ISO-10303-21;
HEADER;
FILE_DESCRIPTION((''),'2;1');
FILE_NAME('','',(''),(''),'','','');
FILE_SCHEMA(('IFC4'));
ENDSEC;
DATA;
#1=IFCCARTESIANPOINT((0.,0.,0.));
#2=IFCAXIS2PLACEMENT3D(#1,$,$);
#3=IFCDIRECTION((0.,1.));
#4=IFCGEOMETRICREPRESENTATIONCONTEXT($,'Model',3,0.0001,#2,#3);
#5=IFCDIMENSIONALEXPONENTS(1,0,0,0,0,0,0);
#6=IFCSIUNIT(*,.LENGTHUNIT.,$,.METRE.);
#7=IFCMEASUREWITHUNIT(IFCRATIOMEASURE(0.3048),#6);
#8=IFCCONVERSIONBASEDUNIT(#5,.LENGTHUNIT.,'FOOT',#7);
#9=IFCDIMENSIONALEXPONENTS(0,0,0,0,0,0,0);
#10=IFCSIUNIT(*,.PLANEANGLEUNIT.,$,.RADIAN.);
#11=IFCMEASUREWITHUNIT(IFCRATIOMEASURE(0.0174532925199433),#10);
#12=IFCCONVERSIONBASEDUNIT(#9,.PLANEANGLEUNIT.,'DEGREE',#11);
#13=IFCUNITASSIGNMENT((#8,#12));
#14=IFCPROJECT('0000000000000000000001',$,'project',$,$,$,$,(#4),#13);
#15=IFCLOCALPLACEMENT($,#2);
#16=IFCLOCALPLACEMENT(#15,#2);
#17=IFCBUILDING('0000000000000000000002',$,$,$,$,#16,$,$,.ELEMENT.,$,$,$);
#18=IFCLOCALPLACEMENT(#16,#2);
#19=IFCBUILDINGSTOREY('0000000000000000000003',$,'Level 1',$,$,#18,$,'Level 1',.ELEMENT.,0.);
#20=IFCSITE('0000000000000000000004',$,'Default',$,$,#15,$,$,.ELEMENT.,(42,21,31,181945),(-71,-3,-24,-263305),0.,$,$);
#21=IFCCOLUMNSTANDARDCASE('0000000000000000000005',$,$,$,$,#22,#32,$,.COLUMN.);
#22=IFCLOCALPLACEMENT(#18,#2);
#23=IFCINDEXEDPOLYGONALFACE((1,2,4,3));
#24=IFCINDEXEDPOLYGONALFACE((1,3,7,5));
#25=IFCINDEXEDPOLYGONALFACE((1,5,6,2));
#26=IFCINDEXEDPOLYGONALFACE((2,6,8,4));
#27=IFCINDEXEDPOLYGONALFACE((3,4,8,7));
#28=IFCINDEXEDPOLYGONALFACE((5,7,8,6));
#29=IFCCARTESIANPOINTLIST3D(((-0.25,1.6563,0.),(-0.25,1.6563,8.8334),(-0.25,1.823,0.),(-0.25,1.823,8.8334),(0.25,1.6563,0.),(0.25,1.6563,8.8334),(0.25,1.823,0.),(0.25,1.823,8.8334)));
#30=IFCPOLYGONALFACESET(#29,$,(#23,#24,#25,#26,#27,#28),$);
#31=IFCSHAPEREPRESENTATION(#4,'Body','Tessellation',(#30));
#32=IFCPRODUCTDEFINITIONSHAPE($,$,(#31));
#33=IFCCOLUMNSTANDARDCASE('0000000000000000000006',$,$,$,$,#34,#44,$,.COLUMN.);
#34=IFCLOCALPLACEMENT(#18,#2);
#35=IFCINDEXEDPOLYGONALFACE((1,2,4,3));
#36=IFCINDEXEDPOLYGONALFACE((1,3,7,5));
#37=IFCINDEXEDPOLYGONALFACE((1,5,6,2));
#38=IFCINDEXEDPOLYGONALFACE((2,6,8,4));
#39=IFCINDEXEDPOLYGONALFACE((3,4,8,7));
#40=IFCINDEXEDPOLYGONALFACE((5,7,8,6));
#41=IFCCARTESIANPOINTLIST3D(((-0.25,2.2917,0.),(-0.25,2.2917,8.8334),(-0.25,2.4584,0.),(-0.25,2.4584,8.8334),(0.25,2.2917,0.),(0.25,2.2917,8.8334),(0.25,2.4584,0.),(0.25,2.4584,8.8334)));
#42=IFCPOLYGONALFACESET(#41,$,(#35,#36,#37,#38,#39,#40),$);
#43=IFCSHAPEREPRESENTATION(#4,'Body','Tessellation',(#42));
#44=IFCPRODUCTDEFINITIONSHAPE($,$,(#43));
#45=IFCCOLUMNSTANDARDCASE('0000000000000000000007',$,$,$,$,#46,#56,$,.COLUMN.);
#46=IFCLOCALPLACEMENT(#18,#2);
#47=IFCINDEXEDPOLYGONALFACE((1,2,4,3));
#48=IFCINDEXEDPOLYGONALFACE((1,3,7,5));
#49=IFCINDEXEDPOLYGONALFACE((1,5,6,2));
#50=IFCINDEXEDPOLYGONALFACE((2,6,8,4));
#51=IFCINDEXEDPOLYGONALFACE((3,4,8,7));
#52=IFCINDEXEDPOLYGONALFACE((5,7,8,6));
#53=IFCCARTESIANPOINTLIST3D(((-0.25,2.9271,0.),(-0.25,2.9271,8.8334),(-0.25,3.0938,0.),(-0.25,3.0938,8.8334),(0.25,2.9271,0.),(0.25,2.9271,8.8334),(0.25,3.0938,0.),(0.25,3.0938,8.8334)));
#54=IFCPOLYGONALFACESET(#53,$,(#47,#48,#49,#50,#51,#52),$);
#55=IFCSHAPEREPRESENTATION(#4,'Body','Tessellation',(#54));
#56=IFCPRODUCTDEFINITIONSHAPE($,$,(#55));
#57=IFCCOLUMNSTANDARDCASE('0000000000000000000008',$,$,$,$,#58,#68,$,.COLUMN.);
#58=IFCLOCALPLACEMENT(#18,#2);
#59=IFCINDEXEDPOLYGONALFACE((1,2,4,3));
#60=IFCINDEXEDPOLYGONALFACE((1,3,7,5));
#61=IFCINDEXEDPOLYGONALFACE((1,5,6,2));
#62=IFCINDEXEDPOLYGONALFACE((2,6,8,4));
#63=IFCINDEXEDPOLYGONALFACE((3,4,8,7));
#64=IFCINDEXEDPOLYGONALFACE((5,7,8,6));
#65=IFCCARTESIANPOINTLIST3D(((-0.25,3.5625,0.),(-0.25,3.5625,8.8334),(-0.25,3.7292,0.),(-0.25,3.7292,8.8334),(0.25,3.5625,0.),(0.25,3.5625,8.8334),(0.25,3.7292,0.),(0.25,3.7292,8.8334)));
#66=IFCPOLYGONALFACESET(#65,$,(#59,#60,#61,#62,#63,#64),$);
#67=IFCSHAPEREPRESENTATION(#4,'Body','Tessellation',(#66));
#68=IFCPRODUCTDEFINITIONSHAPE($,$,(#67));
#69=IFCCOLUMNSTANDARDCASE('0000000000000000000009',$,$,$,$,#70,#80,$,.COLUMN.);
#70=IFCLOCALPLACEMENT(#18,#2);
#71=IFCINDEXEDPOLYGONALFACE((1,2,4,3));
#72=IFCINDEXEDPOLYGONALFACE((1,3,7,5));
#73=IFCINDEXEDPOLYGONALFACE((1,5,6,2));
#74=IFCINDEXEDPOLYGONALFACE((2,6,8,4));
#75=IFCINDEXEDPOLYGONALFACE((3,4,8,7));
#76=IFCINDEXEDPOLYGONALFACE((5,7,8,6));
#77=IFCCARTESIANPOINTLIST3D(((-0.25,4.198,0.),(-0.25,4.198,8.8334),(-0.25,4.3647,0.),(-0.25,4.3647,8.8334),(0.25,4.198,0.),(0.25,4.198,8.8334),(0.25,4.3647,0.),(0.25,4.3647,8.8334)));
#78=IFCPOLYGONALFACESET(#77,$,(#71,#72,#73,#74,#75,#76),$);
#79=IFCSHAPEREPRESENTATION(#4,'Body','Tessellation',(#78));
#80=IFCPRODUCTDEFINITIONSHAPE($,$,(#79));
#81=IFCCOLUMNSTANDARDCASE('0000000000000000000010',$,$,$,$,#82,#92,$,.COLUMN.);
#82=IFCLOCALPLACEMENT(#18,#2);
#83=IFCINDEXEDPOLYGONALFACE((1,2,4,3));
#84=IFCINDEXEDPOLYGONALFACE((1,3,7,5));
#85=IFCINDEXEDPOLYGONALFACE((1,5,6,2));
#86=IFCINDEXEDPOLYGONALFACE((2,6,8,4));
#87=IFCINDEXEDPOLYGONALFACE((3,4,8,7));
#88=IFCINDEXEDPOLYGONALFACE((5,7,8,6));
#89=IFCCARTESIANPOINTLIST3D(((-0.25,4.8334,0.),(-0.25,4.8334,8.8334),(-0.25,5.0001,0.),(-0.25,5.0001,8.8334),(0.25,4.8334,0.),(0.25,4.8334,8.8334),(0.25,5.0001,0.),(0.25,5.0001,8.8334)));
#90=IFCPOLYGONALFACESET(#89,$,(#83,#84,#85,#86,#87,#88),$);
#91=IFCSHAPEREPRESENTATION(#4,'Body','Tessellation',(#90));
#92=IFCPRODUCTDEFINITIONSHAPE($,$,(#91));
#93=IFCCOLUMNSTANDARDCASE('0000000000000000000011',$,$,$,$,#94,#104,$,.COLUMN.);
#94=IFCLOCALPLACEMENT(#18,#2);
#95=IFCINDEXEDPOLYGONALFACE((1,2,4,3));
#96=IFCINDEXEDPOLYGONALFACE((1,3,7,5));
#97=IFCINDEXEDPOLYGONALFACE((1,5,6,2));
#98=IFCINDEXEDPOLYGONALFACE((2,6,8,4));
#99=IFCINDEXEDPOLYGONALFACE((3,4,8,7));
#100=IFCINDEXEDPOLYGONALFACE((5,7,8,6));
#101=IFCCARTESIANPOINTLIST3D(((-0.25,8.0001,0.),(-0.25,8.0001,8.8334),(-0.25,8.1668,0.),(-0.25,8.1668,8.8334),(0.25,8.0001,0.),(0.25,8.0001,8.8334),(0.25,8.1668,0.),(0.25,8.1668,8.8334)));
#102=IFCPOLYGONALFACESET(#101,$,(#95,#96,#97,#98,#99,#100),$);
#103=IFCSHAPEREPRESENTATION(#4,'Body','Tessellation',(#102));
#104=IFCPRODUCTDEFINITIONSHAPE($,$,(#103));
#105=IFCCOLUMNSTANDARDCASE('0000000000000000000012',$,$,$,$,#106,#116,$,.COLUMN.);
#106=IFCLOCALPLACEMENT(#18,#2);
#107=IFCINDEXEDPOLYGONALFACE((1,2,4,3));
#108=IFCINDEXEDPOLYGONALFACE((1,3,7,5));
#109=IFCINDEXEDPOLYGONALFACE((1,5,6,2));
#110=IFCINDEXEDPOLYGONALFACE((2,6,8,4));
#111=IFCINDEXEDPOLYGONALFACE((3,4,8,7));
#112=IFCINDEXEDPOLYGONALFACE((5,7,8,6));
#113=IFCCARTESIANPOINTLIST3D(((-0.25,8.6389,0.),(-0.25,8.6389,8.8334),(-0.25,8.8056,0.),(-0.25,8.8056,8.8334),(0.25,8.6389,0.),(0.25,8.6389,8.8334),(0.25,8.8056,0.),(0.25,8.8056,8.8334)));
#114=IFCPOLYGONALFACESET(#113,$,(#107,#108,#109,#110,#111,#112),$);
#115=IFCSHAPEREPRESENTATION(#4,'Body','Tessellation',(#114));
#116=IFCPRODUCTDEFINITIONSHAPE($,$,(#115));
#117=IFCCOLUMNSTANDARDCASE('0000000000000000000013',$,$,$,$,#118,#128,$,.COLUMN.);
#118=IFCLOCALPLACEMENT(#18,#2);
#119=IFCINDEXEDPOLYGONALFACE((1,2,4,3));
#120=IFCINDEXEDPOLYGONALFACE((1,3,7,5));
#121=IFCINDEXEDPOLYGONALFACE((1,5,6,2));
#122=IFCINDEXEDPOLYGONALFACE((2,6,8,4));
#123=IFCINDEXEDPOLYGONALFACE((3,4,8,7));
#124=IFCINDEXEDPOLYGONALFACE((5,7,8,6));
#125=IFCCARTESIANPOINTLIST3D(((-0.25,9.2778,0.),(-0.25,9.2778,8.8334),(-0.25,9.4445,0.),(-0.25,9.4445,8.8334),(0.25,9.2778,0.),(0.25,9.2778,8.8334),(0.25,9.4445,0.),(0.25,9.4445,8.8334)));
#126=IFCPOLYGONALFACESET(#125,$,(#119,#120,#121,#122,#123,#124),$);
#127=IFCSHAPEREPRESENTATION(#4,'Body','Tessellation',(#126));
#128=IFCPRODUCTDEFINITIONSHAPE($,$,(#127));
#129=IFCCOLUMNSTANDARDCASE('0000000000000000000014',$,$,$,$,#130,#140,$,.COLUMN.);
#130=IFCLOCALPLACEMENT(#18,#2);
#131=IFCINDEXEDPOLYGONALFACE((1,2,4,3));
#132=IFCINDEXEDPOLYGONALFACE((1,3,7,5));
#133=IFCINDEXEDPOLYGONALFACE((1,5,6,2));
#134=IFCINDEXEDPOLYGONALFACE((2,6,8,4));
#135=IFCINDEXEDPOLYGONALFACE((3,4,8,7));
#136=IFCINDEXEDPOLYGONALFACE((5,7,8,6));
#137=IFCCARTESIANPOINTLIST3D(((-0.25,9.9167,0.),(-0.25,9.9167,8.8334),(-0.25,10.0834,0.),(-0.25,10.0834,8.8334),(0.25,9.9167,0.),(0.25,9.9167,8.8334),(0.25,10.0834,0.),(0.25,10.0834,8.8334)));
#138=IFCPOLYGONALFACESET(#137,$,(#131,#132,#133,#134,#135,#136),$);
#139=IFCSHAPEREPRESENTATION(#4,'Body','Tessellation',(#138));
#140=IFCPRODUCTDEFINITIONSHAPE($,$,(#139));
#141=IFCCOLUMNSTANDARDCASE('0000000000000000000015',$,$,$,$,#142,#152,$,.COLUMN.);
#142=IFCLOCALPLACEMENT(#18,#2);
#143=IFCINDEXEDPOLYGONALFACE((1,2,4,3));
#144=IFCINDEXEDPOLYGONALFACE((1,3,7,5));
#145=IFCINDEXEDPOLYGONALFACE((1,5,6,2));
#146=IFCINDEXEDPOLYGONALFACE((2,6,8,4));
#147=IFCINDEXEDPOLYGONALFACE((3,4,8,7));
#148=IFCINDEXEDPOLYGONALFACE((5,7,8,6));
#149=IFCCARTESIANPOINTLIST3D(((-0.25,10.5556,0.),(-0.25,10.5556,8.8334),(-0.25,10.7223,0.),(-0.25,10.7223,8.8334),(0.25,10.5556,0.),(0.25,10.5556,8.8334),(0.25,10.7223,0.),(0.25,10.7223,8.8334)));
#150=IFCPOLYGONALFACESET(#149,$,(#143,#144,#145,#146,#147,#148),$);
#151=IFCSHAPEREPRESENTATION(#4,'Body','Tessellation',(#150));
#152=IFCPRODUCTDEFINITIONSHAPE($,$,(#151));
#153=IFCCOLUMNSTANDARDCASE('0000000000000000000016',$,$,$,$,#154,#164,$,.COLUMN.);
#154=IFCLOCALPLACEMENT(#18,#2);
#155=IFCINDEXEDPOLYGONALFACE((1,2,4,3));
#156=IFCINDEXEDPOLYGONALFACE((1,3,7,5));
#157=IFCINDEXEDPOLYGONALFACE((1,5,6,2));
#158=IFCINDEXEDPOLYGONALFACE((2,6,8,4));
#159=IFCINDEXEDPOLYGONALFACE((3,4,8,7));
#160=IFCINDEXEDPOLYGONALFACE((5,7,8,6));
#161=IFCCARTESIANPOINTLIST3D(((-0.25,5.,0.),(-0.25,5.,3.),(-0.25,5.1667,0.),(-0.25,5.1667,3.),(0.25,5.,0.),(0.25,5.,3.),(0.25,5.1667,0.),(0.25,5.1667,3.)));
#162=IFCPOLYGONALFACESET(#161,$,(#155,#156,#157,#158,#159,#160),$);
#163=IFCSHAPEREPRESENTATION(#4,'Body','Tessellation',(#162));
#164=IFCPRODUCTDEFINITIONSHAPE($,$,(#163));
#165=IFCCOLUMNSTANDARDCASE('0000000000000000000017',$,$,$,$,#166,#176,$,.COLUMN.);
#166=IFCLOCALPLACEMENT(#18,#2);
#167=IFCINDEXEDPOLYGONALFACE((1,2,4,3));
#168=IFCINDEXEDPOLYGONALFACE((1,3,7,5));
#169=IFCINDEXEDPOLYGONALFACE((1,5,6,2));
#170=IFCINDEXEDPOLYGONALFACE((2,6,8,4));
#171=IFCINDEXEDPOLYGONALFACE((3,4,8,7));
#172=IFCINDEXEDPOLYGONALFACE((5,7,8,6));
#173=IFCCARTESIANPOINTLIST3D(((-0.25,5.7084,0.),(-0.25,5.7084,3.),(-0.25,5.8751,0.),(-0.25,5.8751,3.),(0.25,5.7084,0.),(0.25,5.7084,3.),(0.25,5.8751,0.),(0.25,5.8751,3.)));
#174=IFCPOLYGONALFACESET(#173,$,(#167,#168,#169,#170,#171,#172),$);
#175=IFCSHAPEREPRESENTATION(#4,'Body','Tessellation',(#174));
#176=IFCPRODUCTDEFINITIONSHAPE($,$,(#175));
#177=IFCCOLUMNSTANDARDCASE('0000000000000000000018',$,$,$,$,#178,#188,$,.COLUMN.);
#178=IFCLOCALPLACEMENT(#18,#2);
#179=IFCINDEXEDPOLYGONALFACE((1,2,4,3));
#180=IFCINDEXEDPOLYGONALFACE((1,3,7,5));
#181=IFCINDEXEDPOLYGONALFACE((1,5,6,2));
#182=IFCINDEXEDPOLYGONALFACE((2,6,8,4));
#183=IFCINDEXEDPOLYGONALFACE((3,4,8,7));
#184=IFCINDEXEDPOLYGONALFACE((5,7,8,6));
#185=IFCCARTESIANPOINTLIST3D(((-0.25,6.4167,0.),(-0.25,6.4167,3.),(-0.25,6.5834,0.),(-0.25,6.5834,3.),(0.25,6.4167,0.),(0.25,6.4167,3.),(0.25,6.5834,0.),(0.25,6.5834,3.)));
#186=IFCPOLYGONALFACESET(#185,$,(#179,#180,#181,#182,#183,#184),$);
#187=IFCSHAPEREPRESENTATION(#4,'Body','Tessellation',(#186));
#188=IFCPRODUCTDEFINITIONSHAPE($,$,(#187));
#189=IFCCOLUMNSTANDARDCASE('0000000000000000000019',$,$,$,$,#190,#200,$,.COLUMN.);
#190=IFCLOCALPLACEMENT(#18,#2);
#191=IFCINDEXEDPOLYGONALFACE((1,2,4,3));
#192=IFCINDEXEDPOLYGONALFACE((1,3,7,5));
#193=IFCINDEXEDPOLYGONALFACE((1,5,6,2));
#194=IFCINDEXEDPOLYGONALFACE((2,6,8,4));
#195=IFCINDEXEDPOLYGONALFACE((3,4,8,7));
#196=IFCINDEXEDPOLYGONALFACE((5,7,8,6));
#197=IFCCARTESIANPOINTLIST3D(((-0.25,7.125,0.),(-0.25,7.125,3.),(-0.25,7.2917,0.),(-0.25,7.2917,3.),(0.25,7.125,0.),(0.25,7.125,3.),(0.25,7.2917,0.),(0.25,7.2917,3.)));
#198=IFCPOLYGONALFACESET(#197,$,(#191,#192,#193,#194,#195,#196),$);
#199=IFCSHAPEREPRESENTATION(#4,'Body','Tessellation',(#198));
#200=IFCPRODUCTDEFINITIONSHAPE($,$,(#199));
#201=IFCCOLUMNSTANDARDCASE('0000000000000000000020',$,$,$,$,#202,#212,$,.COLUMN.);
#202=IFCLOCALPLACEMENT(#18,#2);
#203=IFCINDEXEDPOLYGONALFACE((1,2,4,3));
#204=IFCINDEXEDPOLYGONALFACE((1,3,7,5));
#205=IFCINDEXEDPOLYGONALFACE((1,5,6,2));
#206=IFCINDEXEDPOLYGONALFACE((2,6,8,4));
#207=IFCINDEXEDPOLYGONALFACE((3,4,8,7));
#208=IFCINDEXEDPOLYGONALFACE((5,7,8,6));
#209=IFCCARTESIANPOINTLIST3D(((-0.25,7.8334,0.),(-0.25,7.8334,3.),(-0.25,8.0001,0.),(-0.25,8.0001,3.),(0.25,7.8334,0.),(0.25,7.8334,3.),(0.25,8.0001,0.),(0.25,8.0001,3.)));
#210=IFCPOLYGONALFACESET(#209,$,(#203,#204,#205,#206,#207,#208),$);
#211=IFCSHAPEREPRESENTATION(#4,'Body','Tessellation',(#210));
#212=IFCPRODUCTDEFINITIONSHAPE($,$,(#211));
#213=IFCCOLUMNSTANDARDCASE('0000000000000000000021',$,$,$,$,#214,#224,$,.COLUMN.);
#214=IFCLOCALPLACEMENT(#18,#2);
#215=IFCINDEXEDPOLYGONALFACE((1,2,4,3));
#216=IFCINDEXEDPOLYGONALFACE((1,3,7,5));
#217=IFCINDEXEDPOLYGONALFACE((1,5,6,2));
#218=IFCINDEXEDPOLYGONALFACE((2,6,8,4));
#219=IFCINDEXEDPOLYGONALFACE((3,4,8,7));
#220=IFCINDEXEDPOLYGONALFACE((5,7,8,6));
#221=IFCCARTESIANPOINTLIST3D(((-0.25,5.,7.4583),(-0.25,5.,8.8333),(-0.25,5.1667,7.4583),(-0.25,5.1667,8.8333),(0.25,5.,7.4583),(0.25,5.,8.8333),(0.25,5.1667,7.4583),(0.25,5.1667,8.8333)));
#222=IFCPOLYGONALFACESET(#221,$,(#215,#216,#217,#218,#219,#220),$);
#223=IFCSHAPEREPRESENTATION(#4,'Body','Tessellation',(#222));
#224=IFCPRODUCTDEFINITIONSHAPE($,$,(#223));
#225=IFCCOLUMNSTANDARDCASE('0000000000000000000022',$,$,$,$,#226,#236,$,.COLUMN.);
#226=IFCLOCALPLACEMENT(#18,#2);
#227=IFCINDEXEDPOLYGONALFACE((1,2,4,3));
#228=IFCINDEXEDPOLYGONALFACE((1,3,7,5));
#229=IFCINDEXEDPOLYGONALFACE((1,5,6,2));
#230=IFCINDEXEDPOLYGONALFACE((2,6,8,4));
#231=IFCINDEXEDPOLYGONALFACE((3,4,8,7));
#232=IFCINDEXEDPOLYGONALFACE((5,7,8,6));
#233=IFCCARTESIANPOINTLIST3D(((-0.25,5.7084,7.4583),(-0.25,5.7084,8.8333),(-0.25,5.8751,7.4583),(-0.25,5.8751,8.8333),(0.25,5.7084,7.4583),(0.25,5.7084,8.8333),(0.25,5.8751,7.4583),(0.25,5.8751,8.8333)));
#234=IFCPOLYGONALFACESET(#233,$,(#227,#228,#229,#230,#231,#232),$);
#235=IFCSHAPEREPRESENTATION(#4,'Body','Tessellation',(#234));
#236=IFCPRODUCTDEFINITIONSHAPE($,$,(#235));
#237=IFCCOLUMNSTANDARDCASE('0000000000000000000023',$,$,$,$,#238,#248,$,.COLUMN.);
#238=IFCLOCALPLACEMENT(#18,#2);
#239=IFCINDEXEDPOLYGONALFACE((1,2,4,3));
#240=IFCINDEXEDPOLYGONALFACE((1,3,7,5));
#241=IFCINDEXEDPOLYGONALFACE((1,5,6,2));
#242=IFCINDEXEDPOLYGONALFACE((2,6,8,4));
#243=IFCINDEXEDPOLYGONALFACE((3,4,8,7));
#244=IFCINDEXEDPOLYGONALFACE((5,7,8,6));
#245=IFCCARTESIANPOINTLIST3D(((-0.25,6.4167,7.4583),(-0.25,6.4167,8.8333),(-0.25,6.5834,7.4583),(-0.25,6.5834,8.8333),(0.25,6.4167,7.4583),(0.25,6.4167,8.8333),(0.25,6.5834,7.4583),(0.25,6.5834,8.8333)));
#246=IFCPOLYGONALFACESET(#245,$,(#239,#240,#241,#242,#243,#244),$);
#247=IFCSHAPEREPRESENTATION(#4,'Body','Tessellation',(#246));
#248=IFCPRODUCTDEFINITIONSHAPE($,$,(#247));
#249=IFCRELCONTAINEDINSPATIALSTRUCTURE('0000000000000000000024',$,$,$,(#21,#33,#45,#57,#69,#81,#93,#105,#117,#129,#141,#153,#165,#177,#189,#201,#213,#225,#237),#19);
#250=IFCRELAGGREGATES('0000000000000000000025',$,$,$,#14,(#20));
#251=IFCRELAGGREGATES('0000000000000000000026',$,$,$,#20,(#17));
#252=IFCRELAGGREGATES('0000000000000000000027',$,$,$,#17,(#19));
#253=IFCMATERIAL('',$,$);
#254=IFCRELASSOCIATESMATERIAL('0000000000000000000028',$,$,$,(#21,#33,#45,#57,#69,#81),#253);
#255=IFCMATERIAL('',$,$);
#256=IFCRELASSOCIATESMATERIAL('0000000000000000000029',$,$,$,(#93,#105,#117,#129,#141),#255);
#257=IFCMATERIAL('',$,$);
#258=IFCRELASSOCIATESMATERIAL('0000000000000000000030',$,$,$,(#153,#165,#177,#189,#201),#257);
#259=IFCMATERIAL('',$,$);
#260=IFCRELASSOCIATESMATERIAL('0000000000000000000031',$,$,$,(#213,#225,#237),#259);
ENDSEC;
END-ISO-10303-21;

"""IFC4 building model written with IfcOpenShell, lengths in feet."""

from ifc_helpers import new_model, entity, si_unit, converted_unit, direction, frame, origin, place, context, project, spatial, rectangle, extrude, material, element, save


model = new_model("IFC4")

# Units and contexts
model_context = context("Model", 3, precision=0.0001, world=origin(), true_north=direction((0.0, 1.0)))
ifc_project = project(units=[converted_unit("LENGTHUNIT", "FOOT", entity("IfcRatioMeasure", 0.3048), si_unit("LENGTHUNIT", "METRE"), dimensions=[1, 0, 0, 0, 0, 0, 0]), converted_unit("PLANEANGLEUNIT", "DEGREE", entity("IfcRatioMeasure", 0.0174532925199433), si_unit("PLANEANGLEUNIT", "RADIAN"), dimensions=[0, 0, 0, 0, 0, 0, 0])], contexts=[model_context])

# Site, building, storey
site_placement = place(None, origin())
site = spatial("IfcSite", under=ifc_project, at=site_placement, Name="Default", CompositionType="ELEMENT", RefLatitude=(42, 21, 31, 181945), RefLongitude=(-71, -3, -24, -263305), RefElevation=0.0)
building_placement = place(site_placement, origin())
building = spatial("IfcBuilding", under=site, at=building_placement, CompositionType="ELEMENT")
storey_placement = place(building_placement, origin())
storey = spatial("IfcBuildingStorey", under=building, at=storey_placement, Name="Level 1", LongName="Level 1", CompositionType="ELEMENT", Elevation=0.0)

# Columns
ifc_material_1 = material(Name="")
placement_1 = place(storey_placement, frame((0.0, -0.25, 0.0), z_axis=(0.0, 0.0, 1.0), x_axis=(0.0, 1.0, 0.0)))
for number, where, z_axis, x_axis in (
    (1, (1.9896, 0.0, 0.0), (0.0, 0.0, 1.0), (1.0, 0.0, 0.0)),
    (2, (2.625, 0.0, 0.0), (0.0, 0.0, 1.0), (1.0, 0.0, 0.0)),
    (3, (3.2604, 0.0, 0.0), (0.0, 0.0, 1.0), (1.0, 0.0, 0.0)),
    (4, (3.8958, 0.0, 0.0), (0.0, 0.0, 1.0), (1.0, 0.0, 0.0)),
    (5, (4.5313, 0.0, 0.0), (0.0, 0.0, 1.0), (1.0, 0.0, 0.0)),
    (6, (5.1667, 0.0, 0.0), (0.0, 0.0, 1.0), (1.0, 0.0, 0.0)),
):
    element("IfcColumnStandardCase", number, at=place(placement_1, frame(where, z_axis=z_axis, x_axis=x_axis)), inside=storey, material=ifc_material_1, PredefinedType="COLUMN", context=model_context, shape_type="SweptSolid", body=[
        extrude(rectangle(XDim=0.1667, YDim=0.5), origin(), (0.0, 0.0, 1.0), 8.8334),
    ])
ifc_material_2 = material(Name="")
for number, where, z_axis, x_axis in (
    (7, (8.3334, 0.0, 0.0), (0.0, 0.0, 1.0), (1.0, 0.0, 0.0)),
    (8, (8.9722, 0.0, 0.0), (0.0, 0.0, 1.0), (1.0, 0.0, 0.0)),
    (9, (9.6111, 0.0, 0.0), (0.0, 0.0, 1.0), (1.0, 0.0, 0.0)),
    (10, (10.25, 0.0, 0.0), (0.0, 0.0, 1.0), (1.0, 0.0, 0.0)),
    (11, (10.8889, 0.0, 0.0), (0.0, 0.0, 1.0), (1.0, 0.0, 0.0)),
):
    element("IfcColumnStandardCase", number, at=place(placement_1, frame(where, z_axis=z_axis, x_axis=x_axis)), inside=storey, material=ifc_material_2, PredefinedType="COLUMN", context=model_context, shape_type="SweptSolid", body=[
        extrude(rectangle(XDim=0.1667, YDim=0.5), origin(), (0.0, 0.0, 1.0), 8.8334),
    ])
ifc_material_3 = material(Name="")
for number, where, z_axis, x_axis in (
    (12, (5.3333, 0.0, 0.0), (0.0, 0.0, 1.0), (1.0, 0.0, 0.0)),
    (13, (6.0417, 0.0, 0.0), (0.0, 0.0, 1.0), (1.0, 0.0, 0.0)),
    (14, (6.75, 0.0, 0.0), (0.0, 0.0, 1.0), (1.0, 0.0, 0.0)),
    (15, (7.4583, 0.0, 0.0), (0.0, 0.0, 1.0), (1.0, 0.0, 0.0)),
    (16, (8.1667, 0.0, 0.0), (0.0, 0.0, 1.0), (1.0, 0.0, 0.0)),
):
    element("IfcColumnStandardCase", number, at=place(placement_1, frame(where, z_axis=z_axis, x_axis=x_axis)), inside=storey, material=ifc_material_3, PredefinedType="COLUMN", context=model_context, shape_type="SweptSolid", body=[
        extrude(rectangle(XDim=0.1667, YDim=0.5), origin(), (0.0, 0.0, 1.0), 3.0),
    ])
ifc_material_4 = material(Name="")
for number, where, z_axis, x_axis in (
    (17, (5.3333, 0.0, 7.4583), (0.0, 0.0, 1.0), (1.0, 0.0, 0.0)),
    (18, (6.0417, 0.0, 7.4583), (0.0, 0.0, 1.0), (1.0, 0.0, 0.0)),
    (19, (6.75, 0.0, 7.4583), (0.0, 0.0, 1.0), (1.0, 0.0, 0.0)),
):
    element("IfcColumnStandardCase", number, at=place(placement_1, frame(where, z_axis=z_axis, x_axis=x_axis)), inside=storey, material=ifc_material_4, PredefinedType="COLUMN", context=model_context, shape_type="SweptSolid", body=[
        extrude(rectangle(XDim=0.1667, YDim=0.5), origin(), (0.0, 0.0, 1.0), 1.375),
    ])

save(model, "model.ifc")
